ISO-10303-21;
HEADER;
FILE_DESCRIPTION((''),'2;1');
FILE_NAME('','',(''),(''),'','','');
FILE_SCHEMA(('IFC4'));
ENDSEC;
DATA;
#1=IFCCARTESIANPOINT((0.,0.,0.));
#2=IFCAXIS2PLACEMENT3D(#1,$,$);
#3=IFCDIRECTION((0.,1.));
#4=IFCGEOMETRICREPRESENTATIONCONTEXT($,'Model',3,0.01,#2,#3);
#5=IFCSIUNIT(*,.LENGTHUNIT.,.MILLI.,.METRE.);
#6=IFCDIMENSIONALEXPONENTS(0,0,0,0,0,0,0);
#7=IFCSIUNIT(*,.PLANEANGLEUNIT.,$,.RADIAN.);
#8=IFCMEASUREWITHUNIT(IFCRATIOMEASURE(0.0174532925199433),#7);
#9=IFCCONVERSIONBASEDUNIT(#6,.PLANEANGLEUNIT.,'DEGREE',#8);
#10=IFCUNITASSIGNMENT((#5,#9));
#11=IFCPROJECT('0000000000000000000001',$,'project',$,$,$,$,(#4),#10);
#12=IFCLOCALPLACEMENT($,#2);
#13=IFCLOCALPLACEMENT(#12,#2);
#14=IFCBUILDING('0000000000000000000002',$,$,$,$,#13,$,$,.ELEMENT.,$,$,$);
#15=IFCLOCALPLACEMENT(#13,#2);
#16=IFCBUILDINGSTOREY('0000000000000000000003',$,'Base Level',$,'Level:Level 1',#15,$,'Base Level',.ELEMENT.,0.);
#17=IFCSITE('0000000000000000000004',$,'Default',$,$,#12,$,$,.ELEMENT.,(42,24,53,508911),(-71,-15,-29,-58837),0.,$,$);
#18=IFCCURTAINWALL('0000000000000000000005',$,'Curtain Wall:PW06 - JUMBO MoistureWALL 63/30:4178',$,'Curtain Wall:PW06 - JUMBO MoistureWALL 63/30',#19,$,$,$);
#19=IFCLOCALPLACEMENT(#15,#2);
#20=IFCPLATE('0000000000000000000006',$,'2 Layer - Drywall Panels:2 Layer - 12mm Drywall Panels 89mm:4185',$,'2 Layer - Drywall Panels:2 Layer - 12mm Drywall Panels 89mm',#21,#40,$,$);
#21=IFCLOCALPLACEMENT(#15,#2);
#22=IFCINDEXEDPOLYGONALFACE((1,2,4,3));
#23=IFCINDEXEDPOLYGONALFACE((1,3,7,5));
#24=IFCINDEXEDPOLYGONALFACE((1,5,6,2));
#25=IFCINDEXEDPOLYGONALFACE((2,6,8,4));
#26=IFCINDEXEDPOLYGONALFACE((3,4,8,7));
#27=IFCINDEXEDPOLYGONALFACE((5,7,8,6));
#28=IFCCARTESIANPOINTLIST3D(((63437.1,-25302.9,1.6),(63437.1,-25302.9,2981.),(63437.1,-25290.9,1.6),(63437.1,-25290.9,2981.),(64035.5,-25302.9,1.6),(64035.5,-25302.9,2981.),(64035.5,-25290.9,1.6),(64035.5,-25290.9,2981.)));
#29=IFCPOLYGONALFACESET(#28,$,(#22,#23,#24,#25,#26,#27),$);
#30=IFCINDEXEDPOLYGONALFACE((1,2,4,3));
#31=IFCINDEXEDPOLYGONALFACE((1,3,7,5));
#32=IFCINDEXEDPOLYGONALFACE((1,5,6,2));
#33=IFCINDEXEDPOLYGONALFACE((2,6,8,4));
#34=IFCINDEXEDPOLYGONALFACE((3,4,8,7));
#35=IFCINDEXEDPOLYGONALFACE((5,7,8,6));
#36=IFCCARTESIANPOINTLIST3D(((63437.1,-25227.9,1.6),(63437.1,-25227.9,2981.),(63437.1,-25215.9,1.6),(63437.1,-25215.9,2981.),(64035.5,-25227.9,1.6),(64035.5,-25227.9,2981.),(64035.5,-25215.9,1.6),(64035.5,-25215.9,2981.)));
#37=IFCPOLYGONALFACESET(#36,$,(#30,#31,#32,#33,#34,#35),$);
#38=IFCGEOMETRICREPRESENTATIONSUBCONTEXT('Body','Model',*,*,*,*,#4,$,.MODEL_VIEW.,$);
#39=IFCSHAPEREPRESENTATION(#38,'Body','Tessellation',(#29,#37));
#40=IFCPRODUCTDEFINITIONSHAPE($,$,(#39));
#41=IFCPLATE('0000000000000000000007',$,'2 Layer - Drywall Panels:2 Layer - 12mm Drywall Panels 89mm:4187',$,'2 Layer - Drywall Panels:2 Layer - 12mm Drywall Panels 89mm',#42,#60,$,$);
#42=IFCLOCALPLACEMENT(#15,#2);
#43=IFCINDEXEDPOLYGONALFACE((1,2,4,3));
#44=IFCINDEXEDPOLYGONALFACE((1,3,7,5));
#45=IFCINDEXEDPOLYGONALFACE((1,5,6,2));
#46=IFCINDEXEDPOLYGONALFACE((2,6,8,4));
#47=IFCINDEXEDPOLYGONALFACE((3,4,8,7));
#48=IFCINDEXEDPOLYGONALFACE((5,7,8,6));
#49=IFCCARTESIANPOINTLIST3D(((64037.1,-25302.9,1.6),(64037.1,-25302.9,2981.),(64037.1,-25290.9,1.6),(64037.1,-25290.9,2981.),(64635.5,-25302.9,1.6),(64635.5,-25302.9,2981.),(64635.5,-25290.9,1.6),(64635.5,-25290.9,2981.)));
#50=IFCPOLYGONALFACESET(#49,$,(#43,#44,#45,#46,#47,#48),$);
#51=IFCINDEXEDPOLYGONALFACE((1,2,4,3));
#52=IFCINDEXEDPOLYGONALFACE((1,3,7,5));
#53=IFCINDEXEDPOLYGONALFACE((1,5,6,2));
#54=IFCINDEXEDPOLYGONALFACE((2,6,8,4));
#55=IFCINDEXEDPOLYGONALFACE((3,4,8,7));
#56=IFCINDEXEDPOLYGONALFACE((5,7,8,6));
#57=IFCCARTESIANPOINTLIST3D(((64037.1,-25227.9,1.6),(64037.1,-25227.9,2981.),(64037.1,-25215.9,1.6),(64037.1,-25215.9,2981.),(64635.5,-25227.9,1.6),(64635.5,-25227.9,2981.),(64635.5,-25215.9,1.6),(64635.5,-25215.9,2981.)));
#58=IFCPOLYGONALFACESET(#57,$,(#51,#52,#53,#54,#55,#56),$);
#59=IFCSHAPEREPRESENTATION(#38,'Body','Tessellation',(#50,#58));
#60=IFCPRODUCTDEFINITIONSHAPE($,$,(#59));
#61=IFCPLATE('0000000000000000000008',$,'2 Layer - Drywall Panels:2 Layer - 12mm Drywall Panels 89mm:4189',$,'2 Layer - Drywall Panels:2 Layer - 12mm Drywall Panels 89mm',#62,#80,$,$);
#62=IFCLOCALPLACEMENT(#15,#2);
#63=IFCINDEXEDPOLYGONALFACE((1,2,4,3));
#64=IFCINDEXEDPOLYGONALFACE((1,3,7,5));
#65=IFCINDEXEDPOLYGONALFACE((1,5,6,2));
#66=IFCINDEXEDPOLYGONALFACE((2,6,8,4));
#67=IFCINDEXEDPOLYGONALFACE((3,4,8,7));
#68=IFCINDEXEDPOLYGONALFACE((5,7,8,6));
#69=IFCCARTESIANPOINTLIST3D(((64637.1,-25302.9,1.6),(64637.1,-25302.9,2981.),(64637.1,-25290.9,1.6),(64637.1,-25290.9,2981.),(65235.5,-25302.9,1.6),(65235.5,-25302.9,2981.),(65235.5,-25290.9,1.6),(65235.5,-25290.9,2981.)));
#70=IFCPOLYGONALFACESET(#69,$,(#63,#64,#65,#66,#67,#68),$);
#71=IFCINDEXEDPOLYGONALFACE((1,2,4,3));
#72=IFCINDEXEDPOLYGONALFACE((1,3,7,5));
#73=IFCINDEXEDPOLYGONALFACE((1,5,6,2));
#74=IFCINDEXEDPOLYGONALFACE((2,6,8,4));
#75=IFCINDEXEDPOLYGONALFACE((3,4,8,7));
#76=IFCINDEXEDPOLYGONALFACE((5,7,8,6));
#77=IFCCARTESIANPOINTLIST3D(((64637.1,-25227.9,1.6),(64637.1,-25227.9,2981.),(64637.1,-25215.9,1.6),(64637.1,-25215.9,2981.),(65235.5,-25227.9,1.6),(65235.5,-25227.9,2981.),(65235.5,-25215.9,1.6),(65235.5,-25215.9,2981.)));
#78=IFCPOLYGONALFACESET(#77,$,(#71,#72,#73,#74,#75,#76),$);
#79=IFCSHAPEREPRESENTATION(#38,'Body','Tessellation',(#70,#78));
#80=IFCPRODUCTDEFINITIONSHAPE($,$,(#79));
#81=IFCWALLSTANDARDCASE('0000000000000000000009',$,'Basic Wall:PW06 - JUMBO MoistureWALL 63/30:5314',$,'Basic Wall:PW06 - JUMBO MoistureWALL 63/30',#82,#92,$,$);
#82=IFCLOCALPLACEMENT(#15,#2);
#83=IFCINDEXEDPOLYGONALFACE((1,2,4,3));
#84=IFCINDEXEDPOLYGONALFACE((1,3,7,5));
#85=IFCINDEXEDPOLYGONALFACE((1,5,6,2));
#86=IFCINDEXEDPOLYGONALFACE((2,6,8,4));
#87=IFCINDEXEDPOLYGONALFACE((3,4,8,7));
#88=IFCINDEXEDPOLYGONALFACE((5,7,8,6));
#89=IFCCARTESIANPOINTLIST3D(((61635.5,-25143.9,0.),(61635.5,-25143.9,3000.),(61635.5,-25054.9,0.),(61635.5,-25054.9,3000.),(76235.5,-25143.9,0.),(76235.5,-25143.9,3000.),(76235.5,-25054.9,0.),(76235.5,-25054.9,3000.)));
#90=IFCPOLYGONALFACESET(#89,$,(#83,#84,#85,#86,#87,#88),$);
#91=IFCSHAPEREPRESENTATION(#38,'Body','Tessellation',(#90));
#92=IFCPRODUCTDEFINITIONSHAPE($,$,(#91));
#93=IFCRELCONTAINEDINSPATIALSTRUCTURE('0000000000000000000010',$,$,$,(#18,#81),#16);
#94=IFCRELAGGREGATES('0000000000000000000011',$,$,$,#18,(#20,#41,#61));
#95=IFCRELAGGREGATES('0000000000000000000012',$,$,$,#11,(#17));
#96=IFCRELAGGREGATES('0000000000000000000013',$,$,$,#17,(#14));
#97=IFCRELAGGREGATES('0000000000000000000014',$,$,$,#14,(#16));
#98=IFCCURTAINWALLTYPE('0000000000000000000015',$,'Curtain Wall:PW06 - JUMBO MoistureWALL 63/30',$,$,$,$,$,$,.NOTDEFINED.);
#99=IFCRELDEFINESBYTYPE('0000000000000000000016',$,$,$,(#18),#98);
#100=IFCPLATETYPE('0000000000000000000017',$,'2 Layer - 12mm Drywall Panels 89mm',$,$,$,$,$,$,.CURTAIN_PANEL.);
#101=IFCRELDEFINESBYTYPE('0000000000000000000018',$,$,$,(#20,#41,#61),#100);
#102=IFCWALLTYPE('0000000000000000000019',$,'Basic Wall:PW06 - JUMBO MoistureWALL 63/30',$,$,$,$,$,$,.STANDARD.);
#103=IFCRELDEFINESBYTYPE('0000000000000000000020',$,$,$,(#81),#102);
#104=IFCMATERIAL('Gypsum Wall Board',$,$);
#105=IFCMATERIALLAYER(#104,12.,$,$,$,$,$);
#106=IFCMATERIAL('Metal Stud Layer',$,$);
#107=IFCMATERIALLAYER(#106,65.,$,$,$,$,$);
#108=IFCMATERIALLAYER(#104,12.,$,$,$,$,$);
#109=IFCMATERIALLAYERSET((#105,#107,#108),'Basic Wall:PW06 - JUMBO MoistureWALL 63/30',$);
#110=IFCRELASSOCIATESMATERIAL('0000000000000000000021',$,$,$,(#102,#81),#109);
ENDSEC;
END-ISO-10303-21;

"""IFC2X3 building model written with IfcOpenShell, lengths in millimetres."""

from ifc_helpers import new_model, entity, si_unit, converted_unit, direction, frame, frame_2d, origin, place, context, subcontext, project, spatial, rectangle, extrude, source, transform, mapped, material, layer, layer_set, layer_usage, type_object, type_shapes, element, aggregate, save


model = new_model("IFC2X3")

# Units and contexts
model_context = context("Model", 3, precision=0.01, world=origin(), true_north=direction((0.0, 1.0)))
body_context = subcontext(model_context, "Body", "Model", "MODEL_VIEW")
ifc_project = project(units=[si_unit("LENGTHUNIT", "METRE", prefix="MILLI"), converted_unit("PLANEANGLEUNIT", "DEGREE", entity("IfcRatioMeasure", 0.0174532925199433), si_unit("PLANEANGLEUNIT", "RADIAN"), dimensions=[0, 0, 0, 0, 0, 0, 0])], contexts=[model_context])

# Site, building, storey
site_placement = place(None, origin())
site = spatial("IfcSite", under=ifc_project, at=site_placement, Name="Default", CompositionType="ELEMENT", RefLatitude=(42, 24, 53, 508911), RefLongitude=(-71, -15, -29, -58837), RefElevation=0.0)
building_placement = place(site_placement, origin())
building = spatial("IfcBuilding", under=site, at=building_placement, CompositionType="ELEMENT")
storey_placement = place(building_placement, origin())
storey = spatial("IfcBuildingStorey", under=building, at=storey_placement, Name="Base Level", ObjectType="Level:Level 1", LongName="Base Level", CompositionType="ELEMENT", Elevation=0.0)

# Curtain wall, plates
curtain_wall_type = type_object("IfcCurtainWallType", Name="Curtain Wall:PW06 - JUMBO MoistureWALL 63/30", PredefinedType="NOTDEFINED")
curtain_wall_placement = place(building_placement, origin())
curtain_wall = element("IfcCurtainWall", 1, at=curtain_wall_placement, inside=storey, type_object=curtain_wall_type, Name="Curtain Wall:PW06 - JUMBO MoistureWALL 63/30:4178", ObjectType="Curtain Wall:PW06 - JUMBO MoistureWALL 63/30")
plate_type = type_object("IfcPlateType", Name="2 Layer - 12mm Drywall Panels 89mm", PredefinedType="CURTAIN_PANEL")
shared_shape_1 = source(origin(), body_context, "Body", "SweptSolid", [
    extrude(rectangle(XDim=598.4, YDim=12.0, at=frame_2d((0.0, 0.0), x_axis=(1.0, 0.0))), frame((0.0, -37.5, 0.0), z_axis=(0.0, 0.0, 1.0), x_axis=(-1.0, 0.0, 0.0)), (0.0, 0.0, 1.0), 2979.4),
    extrude(rectangle(XDim=12.0, YDim=598.4, at=frame_2d((0.0, 0.0), x_axis=(1.0, 0.0))), frame((0.0, 37.5, 0.0), z_axis=(0.0, 0.0, 1.0), x_axis=(0.0, 1.0, 0.0)), (0.0, 0.0, 1.0), 2979.4),
])
type_shapes(plate_type, [shared_shape_1])
plate_1_placement = place(curtain_wall_placement, frame((63736.3, -25259.4, 1.6)))
plate_1 = element("IfcPlate", 2, at=plate_1_placement, type_object=plate_type, Name="2 Layer - Drywall Panels:2 Layer - 12mm Drywall Panels 89mm:4185", ObjectType="2 Layer - Drywall Panels:2 Layer - 12mm Drywall Panels 89mm", context=body_context, shape_type="MappedRepresentation", body=[
    mapped(shared_shape_1, transform((0.0, 0.0, 0.0), scale=1.0)),
])
plate_2_placement = place(curtain_wall_placement, frame((64336.3, -25259.4, 1.6)))
plate_2 = element("IfcPlate", 3, at=plate_2_placement, type_object=plate_type, Name="2 Layer - Drywall Panels:2 Layer - 12mm Drywall Panels 89mm:4187", ObjectType="2 Layer - Drywall Panels:2 Layer - 12mm Drywall Panels 89mm", context=body_context, shape_type="MappedRepresentation", body=[
    mapped(shared_shape_1, transform((0.0, 0.0, 0.0), scale=1.0)),
])
plate_3_placement = place(curtain_wall_placement, frame((64936.3, -25259.4, 1.6)))
plate_3 = element("IfcPlate", 4, at=plate_3_placement, type_object=plate_type, Name="2 Layer - Drywall Panels:2 Layer - 12mm Drywall Panels 89mm:4189", ObjectType="2 Layer - Drywall Panels:2 Layer - 12mm Drywall Panels 89mm", context=body_context, shape_type="MappedRepresentation", body=[
    mapped(shared_shape_1, transform((0.0, 0.0, 0.0), scale=1.0)),
])
aggregate(curtain_wall, [plate_1, plate_2, plate_3])

# Wall
ifc_material_1 = material(Name="Gypsum Wall Board")
ifc_layer_1 = layer(ifc_material_1, 12.0)
ifc_material_2 = material(Name="Metal Stud Layer")
ifc_layer_2 = layer(ifc_material_2, 65.0)
ifc_layer_3 = layer(ifc_material_1, 12.0)
ifc_layer_set = layer_set([ifc_layer_1, ifc_layer_2, ifc_layer_3], Name="Basic Wall:PW06 - JUMBO MoistureWALL 63/30")
ifc_layer_usage = layer_usage(ifc_layer_set, "AXIS2", "NEGATIVE", 44.5)
wall_type = type_object("IfcWallType", Name="Basic Wall:PW06 - JUMBO MoistureWALL 63/30", PredefinedType="STANDARD", material=ifc_layer_set)
wall_placement = place(building_placement, frame((61635.5, -25099.4, 0.0)))
element("IfcWallStandardCase", 5, at=wall_placement, inside=storey, type_object=wall_type, material=ifc_layer_usage, Name="Basic Wall:PW06 - JUMBO MoistureWALL 63/30:5314", ObjectType="Basic Wall:PW06 - JUMBO MoistureWALL 63/30", context=body_context, shape_type="SweptSolid", body=[
    extrude(rectangle(XDim=14600.0, YDim=89.0, at=frame_2d((7300.0, 0.0), x_axis=(-1.0, 0.0))), origin(), (0.0, 0.0, 1.0), 3000.0),
])

save(model, "model.ifc")
